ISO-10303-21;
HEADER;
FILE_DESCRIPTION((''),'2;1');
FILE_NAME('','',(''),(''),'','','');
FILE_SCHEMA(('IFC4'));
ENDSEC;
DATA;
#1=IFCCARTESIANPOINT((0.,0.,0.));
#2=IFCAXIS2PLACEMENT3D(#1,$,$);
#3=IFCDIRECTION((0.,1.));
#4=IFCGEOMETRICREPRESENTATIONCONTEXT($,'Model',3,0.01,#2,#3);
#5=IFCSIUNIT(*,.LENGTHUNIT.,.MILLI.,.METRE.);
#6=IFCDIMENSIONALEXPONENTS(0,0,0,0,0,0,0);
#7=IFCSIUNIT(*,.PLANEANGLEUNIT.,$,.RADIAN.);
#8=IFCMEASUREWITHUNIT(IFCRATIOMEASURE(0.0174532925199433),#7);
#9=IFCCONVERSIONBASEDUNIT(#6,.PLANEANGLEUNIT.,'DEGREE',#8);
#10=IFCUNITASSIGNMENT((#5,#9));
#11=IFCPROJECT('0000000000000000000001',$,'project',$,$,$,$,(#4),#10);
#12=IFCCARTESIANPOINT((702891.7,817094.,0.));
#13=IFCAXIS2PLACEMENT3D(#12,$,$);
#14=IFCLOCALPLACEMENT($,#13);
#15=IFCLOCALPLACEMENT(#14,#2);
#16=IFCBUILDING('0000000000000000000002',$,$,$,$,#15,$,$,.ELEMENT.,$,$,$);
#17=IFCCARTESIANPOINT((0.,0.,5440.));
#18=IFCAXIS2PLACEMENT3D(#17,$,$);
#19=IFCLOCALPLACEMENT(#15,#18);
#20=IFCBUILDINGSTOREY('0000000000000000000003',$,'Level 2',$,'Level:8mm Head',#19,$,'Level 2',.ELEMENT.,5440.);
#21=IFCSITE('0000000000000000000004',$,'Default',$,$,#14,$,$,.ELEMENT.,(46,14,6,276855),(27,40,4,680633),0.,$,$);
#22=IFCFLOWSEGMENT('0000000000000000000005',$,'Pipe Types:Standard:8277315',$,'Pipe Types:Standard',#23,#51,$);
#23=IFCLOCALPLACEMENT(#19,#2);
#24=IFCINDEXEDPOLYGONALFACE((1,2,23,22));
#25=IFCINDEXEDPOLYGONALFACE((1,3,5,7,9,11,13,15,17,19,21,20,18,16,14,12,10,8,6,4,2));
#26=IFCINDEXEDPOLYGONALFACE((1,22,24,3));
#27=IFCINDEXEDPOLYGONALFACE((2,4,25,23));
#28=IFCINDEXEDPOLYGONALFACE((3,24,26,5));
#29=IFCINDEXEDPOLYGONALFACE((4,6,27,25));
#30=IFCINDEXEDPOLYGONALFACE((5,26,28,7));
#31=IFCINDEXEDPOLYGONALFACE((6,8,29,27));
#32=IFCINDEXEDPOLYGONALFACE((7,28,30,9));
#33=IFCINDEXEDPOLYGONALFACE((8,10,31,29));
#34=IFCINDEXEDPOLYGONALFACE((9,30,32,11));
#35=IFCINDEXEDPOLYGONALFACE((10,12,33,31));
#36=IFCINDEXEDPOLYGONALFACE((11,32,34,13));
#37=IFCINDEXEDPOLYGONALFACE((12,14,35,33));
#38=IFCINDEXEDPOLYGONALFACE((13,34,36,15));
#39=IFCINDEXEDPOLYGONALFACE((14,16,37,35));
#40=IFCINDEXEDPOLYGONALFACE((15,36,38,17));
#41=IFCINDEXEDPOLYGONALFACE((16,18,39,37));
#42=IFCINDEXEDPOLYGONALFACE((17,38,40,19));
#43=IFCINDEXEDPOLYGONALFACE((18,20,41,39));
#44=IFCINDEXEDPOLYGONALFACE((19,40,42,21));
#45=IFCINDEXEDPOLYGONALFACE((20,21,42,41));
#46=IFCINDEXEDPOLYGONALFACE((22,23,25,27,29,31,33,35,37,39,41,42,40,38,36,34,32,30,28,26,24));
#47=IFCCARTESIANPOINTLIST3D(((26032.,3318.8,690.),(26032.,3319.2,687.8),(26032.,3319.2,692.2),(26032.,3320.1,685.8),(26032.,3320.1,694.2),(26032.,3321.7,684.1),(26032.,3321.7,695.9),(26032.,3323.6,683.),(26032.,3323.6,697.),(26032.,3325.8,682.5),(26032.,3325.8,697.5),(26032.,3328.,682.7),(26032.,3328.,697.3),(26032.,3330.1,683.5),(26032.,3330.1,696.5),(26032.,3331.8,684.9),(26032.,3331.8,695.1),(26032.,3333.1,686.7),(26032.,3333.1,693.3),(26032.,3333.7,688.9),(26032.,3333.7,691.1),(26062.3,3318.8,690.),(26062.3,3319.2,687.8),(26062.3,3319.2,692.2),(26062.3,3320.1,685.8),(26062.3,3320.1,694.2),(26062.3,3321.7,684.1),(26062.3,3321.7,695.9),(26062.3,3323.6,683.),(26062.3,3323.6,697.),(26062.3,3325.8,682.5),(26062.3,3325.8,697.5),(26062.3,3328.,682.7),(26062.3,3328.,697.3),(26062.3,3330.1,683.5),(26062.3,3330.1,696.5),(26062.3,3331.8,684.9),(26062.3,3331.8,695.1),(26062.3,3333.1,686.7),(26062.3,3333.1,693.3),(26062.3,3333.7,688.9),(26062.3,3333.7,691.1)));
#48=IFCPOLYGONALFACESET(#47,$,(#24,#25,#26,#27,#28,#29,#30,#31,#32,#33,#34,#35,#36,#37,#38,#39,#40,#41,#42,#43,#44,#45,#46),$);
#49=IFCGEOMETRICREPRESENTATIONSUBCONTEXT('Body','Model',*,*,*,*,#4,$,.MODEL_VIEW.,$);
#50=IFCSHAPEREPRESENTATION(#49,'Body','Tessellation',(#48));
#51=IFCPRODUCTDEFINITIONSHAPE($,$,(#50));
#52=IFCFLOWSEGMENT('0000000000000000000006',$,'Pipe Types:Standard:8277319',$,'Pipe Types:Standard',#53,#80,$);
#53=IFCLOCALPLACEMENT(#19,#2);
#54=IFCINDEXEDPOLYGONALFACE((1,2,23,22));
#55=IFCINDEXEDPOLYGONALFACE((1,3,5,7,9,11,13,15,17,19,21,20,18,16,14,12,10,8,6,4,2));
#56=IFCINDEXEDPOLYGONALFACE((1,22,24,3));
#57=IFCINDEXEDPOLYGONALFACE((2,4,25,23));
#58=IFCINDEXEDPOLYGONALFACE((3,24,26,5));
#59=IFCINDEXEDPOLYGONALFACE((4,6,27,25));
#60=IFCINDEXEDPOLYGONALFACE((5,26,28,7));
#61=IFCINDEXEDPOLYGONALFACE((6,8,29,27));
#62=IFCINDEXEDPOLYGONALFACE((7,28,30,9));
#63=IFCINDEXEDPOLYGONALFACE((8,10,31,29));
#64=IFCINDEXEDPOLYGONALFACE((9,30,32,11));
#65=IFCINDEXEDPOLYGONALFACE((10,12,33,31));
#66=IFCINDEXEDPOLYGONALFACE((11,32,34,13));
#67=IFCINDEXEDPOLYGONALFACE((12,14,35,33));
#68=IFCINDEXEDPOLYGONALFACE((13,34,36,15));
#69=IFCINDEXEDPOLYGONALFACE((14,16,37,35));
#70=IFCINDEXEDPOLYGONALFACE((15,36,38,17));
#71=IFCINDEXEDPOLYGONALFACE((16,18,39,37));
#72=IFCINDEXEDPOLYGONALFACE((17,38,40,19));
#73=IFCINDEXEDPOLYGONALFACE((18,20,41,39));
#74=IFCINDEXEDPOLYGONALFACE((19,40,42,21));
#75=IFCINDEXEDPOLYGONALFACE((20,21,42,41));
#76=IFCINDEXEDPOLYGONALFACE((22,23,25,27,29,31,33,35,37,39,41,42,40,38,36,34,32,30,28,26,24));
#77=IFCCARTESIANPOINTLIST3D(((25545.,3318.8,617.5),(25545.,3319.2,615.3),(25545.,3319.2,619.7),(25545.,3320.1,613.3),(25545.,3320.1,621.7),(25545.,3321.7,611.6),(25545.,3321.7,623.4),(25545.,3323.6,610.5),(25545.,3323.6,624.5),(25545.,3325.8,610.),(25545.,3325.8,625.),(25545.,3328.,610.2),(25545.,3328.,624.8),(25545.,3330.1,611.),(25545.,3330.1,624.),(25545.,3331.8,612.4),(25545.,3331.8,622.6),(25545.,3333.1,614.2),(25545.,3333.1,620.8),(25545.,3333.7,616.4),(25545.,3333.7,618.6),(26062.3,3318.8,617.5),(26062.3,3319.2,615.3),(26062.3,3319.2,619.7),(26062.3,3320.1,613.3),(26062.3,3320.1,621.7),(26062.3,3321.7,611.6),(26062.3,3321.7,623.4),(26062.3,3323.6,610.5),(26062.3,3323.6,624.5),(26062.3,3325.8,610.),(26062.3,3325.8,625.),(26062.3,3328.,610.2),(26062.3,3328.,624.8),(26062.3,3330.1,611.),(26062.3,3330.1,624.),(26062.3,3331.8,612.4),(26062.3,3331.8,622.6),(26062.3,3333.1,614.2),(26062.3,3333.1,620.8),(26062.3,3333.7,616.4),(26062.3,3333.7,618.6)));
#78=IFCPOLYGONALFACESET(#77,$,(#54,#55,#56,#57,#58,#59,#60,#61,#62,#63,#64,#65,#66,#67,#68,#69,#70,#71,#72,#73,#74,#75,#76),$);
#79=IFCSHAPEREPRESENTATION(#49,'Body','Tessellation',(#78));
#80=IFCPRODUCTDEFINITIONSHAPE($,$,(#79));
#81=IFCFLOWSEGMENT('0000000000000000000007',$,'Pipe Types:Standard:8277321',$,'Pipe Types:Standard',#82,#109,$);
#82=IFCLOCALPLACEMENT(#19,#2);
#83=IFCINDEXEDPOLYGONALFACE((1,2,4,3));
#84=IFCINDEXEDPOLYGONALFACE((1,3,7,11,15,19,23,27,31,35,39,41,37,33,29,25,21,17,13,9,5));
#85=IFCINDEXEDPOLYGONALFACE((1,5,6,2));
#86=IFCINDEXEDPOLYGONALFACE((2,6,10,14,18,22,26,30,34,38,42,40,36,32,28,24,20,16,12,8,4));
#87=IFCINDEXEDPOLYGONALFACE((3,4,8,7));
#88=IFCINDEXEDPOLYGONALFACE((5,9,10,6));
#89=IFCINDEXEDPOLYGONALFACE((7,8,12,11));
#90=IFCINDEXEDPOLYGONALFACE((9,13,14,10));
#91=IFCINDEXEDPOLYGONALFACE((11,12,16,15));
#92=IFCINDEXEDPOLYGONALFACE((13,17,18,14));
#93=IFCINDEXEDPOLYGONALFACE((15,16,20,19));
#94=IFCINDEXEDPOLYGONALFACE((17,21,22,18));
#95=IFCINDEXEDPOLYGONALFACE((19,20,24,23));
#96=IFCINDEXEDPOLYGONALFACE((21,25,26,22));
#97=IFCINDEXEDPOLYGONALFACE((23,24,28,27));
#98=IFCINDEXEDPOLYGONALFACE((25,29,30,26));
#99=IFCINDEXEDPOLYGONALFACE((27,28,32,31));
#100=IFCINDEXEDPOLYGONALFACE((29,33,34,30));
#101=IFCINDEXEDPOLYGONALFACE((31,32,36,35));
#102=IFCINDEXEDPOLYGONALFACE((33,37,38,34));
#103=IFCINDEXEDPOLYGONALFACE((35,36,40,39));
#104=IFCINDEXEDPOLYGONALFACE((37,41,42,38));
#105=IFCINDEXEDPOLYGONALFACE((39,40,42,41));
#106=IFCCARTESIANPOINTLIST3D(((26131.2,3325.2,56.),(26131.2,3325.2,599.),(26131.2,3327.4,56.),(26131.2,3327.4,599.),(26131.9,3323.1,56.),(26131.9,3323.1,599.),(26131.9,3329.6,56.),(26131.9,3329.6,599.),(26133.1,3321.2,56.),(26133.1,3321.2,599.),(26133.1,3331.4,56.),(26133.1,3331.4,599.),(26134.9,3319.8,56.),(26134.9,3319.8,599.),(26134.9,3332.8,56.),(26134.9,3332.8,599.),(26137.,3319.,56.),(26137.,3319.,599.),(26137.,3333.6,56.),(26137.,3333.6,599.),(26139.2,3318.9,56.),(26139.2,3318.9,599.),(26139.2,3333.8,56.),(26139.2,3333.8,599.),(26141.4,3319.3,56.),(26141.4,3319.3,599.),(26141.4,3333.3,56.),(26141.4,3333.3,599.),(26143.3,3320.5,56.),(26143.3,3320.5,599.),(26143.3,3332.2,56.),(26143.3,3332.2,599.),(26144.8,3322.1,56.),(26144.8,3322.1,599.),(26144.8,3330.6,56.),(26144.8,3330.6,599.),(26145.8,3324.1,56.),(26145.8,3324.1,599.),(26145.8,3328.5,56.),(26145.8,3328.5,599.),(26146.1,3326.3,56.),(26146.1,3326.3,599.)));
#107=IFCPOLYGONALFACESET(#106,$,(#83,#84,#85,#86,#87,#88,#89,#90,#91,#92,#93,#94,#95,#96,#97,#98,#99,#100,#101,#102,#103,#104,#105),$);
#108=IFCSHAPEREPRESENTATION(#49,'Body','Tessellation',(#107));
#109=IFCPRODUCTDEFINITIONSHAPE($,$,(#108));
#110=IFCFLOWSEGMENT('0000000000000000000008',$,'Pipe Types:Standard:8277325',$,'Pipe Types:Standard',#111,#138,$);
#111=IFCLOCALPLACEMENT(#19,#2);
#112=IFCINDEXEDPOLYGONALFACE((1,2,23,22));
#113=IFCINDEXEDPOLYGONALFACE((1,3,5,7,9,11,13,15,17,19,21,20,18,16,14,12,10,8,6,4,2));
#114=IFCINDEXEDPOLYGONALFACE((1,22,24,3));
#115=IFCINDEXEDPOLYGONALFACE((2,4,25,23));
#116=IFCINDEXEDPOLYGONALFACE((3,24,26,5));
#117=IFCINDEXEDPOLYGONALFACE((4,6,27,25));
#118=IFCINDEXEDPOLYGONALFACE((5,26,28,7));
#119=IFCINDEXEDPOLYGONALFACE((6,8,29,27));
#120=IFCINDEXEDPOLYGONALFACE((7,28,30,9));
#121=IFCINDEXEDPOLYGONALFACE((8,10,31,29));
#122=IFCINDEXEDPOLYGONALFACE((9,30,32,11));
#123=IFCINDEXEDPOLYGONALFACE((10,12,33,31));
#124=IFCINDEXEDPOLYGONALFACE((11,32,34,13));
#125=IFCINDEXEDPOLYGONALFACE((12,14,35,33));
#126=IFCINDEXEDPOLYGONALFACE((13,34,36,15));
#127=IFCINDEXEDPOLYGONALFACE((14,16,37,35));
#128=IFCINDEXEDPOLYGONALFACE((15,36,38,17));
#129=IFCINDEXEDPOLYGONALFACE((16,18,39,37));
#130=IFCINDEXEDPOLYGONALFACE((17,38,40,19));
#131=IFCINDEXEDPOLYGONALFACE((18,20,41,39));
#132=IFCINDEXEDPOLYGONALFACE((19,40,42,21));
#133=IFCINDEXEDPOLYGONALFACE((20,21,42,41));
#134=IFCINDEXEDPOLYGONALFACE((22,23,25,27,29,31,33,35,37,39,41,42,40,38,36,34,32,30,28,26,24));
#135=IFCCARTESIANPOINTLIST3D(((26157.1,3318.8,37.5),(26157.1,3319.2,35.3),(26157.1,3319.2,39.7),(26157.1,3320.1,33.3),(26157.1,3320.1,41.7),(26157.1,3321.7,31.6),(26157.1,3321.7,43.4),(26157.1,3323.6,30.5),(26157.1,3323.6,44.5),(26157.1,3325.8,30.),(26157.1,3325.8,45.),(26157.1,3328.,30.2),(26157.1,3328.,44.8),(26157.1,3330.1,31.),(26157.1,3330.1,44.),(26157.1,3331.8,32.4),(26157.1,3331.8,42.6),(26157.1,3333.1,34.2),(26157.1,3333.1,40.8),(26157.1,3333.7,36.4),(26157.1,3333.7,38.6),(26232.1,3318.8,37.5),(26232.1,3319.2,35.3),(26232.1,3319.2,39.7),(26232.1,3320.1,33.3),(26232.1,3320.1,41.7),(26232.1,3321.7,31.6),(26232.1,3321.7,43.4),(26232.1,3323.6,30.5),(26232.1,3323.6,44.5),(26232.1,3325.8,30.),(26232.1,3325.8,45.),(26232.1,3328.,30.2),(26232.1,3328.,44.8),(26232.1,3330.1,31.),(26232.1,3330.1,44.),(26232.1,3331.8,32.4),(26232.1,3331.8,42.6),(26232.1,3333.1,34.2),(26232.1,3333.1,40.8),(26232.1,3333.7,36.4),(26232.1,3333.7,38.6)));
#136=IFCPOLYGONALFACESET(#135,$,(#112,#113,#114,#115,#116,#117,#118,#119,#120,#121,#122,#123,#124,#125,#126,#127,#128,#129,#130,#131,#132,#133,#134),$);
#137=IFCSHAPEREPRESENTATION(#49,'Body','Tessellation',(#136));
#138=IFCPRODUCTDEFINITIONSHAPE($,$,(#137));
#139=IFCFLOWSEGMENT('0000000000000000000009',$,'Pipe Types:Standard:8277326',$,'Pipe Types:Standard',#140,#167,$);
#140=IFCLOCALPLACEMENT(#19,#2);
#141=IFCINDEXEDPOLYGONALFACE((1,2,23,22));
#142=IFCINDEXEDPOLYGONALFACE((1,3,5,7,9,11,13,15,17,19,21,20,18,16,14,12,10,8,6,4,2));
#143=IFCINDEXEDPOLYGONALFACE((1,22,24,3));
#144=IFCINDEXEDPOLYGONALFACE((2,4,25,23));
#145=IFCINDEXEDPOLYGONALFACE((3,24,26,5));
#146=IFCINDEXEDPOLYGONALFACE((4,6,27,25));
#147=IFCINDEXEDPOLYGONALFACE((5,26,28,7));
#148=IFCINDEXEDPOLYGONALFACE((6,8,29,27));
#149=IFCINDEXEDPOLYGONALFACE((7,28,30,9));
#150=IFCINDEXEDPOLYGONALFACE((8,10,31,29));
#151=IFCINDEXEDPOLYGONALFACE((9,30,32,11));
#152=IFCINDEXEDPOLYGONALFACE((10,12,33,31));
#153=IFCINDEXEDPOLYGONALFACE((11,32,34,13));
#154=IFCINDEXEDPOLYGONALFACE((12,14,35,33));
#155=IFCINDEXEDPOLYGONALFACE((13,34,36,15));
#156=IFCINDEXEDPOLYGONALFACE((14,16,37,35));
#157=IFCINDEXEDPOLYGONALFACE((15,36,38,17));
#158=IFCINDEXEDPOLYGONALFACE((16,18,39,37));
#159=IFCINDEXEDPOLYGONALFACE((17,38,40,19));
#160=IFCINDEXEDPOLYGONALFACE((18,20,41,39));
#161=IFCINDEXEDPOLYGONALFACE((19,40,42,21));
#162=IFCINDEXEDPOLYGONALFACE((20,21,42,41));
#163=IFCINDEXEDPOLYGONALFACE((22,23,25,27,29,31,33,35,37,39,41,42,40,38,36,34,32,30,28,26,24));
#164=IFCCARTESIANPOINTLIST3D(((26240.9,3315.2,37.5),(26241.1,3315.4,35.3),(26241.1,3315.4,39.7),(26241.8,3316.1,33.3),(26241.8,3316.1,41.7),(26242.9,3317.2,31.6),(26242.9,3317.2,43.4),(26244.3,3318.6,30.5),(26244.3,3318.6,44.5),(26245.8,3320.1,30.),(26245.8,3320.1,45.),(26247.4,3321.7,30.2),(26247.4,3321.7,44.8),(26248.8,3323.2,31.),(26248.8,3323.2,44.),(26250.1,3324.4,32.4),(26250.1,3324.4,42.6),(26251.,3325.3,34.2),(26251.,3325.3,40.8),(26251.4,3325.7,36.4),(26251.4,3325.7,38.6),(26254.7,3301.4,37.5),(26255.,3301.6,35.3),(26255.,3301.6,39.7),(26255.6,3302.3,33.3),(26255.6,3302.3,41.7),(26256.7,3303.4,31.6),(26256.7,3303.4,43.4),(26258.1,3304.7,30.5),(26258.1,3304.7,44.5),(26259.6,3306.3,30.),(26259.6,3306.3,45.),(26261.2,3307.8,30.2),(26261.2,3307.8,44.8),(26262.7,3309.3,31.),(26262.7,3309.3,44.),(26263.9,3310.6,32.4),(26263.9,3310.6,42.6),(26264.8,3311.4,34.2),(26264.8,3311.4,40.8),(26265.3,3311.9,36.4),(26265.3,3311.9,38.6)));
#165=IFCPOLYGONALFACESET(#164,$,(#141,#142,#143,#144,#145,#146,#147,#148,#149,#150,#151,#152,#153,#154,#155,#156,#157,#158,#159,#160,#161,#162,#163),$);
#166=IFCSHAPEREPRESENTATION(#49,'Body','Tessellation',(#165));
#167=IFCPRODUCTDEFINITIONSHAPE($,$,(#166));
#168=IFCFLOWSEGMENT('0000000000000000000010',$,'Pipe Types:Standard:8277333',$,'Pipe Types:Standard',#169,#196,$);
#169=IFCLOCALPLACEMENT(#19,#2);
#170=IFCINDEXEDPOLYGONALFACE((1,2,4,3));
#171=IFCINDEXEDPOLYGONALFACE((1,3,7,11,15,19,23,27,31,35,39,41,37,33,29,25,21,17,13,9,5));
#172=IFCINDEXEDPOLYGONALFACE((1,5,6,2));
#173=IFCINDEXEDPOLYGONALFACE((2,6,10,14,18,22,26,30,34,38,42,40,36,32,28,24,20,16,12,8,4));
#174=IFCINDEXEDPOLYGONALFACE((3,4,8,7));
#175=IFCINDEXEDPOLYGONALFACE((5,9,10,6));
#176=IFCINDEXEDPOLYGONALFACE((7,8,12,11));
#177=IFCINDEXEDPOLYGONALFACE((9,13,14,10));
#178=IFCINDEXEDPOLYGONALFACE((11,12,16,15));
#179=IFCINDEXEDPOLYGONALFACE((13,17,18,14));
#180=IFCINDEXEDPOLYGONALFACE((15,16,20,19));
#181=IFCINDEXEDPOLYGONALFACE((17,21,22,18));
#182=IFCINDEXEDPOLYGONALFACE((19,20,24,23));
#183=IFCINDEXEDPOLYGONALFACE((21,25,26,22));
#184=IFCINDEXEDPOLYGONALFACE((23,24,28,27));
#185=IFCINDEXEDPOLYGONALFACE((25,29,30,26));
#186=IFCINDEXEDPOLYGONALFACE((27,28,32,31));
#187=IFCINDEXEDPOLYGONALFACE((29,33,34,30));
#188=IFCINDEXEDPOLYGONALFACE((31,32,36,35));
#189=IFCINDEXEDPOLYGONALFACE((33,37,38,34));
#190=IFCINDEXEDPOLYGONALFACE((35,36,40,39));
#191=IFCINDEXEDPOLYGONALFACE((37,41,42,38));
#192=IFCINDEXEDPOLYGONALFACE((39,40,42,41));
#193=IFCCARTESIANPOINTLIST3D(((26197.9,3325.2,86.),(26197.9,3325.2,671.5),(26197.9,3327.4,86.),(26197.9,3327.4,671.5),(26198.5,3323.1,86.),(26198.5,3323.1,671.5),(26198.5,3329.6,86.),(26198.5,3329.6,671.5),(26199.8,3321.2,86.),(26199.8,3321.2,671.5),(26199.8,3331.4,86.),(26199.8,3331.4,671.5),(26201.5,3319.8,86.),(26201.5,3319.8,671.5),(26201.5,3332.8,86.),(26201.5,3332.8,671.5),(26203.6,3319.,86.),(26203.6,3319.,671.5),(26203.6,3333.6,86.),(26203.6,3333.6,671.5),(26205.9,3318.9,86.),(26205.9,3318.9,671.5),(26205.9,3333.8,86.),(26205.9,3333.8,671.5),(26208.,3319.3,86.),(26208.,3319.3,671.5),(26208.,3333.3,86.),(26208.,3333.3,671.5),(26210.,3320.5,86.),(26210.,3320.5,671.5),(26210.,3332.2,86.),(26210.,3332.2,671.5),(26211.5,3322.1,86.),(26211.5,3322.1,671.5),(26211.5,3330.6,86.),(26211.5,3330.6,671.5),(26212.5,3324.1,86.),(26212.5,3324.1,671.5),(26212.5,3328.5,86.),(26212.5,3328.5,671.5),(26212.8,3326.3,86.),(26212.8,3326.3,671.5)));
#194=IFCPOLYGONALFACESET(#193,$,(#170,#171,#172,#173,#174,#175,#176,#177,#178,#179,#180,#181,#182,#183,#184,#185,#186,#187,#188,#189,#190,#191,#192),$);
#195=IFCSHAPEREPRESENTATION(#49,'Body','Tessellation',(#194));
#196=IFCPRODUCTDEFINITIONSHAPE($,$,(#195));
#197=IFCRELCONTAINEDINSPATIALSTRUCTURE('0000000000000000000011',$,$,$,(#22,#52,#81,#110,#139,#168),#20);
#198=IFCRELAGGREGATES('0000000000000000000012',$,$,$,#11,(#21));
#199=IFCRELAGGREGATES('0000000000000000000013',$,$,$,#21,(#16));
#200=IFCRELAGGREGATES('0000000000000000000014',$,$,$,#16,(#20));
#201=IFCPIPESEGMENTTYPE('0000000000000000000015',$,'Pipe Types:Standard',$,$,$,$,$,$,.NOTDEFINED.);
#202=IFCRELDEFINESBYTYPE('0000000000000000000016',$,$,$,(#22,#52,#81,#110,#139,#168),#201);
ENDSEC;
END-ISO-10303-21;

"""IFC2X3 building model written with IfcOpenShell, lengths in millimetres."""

from ifc_helpers import new_model, entity, si_unit, converted_unit, direction, frame, frame_2d, origin, origin_2d_with_axis, place, context, subcontext, project, spatial, circle, extrude, type_object, element, save


model = new_model("IFC2X3")

# Units and contexts
model_context = context("Model", 3, precision=0.01, world=origin(), true_north=direction((0.0, 1.0)))
body_context = subcontext(model_context, "Body", "Model", "MODEL_VIEW")
ifc_project = project(units=[si_unit("LENGTHUNIT", "METRE", prefix="MILLI"), converted_unit("PLANEANGLEUNIT", "DEGREE", entity("IfcRatioMeasure", 0.0174532925199433), si_unit("PLANEANGLEUNIT", "RADIAN"), dimensions=[0, 0, 0, 0, 0, 0, 0])], contexts=[model_context])

# Site, building, storey
site_placement = place(None, frame((702891.7, 817094.0, 0.0)))
site = spatial("IfcSite", under=ifc_project, at=site_placement, Name="Default", CompositionType="ELEMENT", RefLatitude=(46, 14, 6, 276855), RefLongitude=(27, 40, 4, 680633), RefElevation=0.0)
building_placement = place(site_placement, origin())
building = spatial("IfcBuilding", under=site, at=building_placement, CompositionType="ELEMENT")
storey_placement = place(building_placement, frame((0.0, 0.0, 5440.0)))
storey = spatial("IfcBuildingStorey", under=building, at=storey_placement, Name="Level 2", ObjectType="Level:8mm Head", LongName="Level 2", CompositionType="ELEMENT", Elevation=5440.0)

# Flow segments
pipe_segment_type = type_object("IfcPipeSegmentType", Name="Pipe Types:Standard", PredefinedType="NOTDEFINED")
flow_segment_1_placement = place(storey_placement, origin())
element("IfcFlowSegment", 1, at=flow_segment_1_placement, inside=storey, type_object=pipe_segment_type, Name="Pipe Types:Standard:8277315", ObjectType="Pipe Types:Standard", context=body_context, shape_type="SweptSolid", body=[
    extrude(circle(Radius=7.5, at=frame_2d((0.0, 0.0), x_axis=(1.0, 0.0))), frame((26032.0, 3326.3, 690.0), z_axis=(1.0, 0.0, 0.0), x_axis=(0.0, -1.0, 0.0)), (0.0, 0.0, 1.0), 30.3),
])
flow_segment_2_placement = place(storey_placement, origin())
element("IfcFlowSegment", 2, at=flow_segment_2_placement, inside=storey, type_object=pipe_segment_type, Name="Pipe Types:Standard:8277319", ObjectType="Pipe Types:Standard", context=body_context, shape_type="SweptSolid", body=[
    extrude(circle(Radius=7.5, at=origin_2d_with_axis()), frame((25545.0, 3326.3, 617.5), z_axis=(1.0, 0.0, 0.0), x_axis=(0.0, -1.0, 0.0)), (0.0, 0.0, 1.0), 517.3),
])
flow_segment_3_placement = place(storey_placement, origin())
element("IfcFlowSegment", 3, at=flow_segment_3_placement, inside=storey, type_object=pipe_segment_type, Name="Pipe Types:Standard:8277321", ObjectType="Pipe Types:Standard", context=body_context, shape_type="SweptSolid", body=[
    extrude(circle(Radius=7.5, at=frame_2d((0.0, 0.0), x_axis=(1.0, 0.0))), frame((26138.6, 3326.3, 56.0)), (0.0, 0.0, 1.0), 543.0),
])
flow_segment_4_placement = place(storey_placement, origin())
element("IfcFlowSegment", 4, at=flow_segment_4_placement, inside=storey, type_object=pipe_segment_type, Name="Pipe Types:Standard:8277325", ObjectType="Pipe Types:Standard", context=body_context, shape_type="SweptSolid", body=[
    extrude(circle(Radius=7.5, at=origin_2d_with_axis()), frame((26157.1, 3326.3, 37.5), z_axis=(1.0, 0.0, 0.0), x_axis=(0.0, -1.0, 0.0)), (0.0, 0.0, 1.0), 75.0),
])
flow_segment_5_placement = place(storey_placement, origin())
element("IfcFlowSegment", 5, at=flow_segment_5_placement, inside=storey, type_object=pipe_segment_type, Name="Pipe Types:Standard:8277326", ObjectType="Pipe Types:Standard", context=body_context, shape_type="SweptSolid", body=[
    extrude(circle(Radius=7.5, at=origin_2d_with_axis()), frame((26260.0, 3306.7, 37.5), z_axis=(-0.707107, 0.707107, 0.0), x_axis=(-0.707107, -0.707107, 0.0)), (0.0, 0.0, 1.0), 19.6),
])
flow_segment_6_placement = place(storey_placement, origin())
element("IfcFlowSegment", 6, at=flow_segment_6_placement, inside=storey, type_object=pipe_segment_type, Name="Pipe Types:Standard:8277333", ObjectType="Pipe Types:Standard", context=body_context, shape_type="SweptSolid", body=[
    extrude(circle(Radius=7.5, at=frame_2d((0.0, 0.0), x_axis=(1.0, 0.0))), frame((26205.3, 3326.3, 86.0)), (0.0, 0.0, 1.0), 585.5),
])

save(model, "model.ifc")
